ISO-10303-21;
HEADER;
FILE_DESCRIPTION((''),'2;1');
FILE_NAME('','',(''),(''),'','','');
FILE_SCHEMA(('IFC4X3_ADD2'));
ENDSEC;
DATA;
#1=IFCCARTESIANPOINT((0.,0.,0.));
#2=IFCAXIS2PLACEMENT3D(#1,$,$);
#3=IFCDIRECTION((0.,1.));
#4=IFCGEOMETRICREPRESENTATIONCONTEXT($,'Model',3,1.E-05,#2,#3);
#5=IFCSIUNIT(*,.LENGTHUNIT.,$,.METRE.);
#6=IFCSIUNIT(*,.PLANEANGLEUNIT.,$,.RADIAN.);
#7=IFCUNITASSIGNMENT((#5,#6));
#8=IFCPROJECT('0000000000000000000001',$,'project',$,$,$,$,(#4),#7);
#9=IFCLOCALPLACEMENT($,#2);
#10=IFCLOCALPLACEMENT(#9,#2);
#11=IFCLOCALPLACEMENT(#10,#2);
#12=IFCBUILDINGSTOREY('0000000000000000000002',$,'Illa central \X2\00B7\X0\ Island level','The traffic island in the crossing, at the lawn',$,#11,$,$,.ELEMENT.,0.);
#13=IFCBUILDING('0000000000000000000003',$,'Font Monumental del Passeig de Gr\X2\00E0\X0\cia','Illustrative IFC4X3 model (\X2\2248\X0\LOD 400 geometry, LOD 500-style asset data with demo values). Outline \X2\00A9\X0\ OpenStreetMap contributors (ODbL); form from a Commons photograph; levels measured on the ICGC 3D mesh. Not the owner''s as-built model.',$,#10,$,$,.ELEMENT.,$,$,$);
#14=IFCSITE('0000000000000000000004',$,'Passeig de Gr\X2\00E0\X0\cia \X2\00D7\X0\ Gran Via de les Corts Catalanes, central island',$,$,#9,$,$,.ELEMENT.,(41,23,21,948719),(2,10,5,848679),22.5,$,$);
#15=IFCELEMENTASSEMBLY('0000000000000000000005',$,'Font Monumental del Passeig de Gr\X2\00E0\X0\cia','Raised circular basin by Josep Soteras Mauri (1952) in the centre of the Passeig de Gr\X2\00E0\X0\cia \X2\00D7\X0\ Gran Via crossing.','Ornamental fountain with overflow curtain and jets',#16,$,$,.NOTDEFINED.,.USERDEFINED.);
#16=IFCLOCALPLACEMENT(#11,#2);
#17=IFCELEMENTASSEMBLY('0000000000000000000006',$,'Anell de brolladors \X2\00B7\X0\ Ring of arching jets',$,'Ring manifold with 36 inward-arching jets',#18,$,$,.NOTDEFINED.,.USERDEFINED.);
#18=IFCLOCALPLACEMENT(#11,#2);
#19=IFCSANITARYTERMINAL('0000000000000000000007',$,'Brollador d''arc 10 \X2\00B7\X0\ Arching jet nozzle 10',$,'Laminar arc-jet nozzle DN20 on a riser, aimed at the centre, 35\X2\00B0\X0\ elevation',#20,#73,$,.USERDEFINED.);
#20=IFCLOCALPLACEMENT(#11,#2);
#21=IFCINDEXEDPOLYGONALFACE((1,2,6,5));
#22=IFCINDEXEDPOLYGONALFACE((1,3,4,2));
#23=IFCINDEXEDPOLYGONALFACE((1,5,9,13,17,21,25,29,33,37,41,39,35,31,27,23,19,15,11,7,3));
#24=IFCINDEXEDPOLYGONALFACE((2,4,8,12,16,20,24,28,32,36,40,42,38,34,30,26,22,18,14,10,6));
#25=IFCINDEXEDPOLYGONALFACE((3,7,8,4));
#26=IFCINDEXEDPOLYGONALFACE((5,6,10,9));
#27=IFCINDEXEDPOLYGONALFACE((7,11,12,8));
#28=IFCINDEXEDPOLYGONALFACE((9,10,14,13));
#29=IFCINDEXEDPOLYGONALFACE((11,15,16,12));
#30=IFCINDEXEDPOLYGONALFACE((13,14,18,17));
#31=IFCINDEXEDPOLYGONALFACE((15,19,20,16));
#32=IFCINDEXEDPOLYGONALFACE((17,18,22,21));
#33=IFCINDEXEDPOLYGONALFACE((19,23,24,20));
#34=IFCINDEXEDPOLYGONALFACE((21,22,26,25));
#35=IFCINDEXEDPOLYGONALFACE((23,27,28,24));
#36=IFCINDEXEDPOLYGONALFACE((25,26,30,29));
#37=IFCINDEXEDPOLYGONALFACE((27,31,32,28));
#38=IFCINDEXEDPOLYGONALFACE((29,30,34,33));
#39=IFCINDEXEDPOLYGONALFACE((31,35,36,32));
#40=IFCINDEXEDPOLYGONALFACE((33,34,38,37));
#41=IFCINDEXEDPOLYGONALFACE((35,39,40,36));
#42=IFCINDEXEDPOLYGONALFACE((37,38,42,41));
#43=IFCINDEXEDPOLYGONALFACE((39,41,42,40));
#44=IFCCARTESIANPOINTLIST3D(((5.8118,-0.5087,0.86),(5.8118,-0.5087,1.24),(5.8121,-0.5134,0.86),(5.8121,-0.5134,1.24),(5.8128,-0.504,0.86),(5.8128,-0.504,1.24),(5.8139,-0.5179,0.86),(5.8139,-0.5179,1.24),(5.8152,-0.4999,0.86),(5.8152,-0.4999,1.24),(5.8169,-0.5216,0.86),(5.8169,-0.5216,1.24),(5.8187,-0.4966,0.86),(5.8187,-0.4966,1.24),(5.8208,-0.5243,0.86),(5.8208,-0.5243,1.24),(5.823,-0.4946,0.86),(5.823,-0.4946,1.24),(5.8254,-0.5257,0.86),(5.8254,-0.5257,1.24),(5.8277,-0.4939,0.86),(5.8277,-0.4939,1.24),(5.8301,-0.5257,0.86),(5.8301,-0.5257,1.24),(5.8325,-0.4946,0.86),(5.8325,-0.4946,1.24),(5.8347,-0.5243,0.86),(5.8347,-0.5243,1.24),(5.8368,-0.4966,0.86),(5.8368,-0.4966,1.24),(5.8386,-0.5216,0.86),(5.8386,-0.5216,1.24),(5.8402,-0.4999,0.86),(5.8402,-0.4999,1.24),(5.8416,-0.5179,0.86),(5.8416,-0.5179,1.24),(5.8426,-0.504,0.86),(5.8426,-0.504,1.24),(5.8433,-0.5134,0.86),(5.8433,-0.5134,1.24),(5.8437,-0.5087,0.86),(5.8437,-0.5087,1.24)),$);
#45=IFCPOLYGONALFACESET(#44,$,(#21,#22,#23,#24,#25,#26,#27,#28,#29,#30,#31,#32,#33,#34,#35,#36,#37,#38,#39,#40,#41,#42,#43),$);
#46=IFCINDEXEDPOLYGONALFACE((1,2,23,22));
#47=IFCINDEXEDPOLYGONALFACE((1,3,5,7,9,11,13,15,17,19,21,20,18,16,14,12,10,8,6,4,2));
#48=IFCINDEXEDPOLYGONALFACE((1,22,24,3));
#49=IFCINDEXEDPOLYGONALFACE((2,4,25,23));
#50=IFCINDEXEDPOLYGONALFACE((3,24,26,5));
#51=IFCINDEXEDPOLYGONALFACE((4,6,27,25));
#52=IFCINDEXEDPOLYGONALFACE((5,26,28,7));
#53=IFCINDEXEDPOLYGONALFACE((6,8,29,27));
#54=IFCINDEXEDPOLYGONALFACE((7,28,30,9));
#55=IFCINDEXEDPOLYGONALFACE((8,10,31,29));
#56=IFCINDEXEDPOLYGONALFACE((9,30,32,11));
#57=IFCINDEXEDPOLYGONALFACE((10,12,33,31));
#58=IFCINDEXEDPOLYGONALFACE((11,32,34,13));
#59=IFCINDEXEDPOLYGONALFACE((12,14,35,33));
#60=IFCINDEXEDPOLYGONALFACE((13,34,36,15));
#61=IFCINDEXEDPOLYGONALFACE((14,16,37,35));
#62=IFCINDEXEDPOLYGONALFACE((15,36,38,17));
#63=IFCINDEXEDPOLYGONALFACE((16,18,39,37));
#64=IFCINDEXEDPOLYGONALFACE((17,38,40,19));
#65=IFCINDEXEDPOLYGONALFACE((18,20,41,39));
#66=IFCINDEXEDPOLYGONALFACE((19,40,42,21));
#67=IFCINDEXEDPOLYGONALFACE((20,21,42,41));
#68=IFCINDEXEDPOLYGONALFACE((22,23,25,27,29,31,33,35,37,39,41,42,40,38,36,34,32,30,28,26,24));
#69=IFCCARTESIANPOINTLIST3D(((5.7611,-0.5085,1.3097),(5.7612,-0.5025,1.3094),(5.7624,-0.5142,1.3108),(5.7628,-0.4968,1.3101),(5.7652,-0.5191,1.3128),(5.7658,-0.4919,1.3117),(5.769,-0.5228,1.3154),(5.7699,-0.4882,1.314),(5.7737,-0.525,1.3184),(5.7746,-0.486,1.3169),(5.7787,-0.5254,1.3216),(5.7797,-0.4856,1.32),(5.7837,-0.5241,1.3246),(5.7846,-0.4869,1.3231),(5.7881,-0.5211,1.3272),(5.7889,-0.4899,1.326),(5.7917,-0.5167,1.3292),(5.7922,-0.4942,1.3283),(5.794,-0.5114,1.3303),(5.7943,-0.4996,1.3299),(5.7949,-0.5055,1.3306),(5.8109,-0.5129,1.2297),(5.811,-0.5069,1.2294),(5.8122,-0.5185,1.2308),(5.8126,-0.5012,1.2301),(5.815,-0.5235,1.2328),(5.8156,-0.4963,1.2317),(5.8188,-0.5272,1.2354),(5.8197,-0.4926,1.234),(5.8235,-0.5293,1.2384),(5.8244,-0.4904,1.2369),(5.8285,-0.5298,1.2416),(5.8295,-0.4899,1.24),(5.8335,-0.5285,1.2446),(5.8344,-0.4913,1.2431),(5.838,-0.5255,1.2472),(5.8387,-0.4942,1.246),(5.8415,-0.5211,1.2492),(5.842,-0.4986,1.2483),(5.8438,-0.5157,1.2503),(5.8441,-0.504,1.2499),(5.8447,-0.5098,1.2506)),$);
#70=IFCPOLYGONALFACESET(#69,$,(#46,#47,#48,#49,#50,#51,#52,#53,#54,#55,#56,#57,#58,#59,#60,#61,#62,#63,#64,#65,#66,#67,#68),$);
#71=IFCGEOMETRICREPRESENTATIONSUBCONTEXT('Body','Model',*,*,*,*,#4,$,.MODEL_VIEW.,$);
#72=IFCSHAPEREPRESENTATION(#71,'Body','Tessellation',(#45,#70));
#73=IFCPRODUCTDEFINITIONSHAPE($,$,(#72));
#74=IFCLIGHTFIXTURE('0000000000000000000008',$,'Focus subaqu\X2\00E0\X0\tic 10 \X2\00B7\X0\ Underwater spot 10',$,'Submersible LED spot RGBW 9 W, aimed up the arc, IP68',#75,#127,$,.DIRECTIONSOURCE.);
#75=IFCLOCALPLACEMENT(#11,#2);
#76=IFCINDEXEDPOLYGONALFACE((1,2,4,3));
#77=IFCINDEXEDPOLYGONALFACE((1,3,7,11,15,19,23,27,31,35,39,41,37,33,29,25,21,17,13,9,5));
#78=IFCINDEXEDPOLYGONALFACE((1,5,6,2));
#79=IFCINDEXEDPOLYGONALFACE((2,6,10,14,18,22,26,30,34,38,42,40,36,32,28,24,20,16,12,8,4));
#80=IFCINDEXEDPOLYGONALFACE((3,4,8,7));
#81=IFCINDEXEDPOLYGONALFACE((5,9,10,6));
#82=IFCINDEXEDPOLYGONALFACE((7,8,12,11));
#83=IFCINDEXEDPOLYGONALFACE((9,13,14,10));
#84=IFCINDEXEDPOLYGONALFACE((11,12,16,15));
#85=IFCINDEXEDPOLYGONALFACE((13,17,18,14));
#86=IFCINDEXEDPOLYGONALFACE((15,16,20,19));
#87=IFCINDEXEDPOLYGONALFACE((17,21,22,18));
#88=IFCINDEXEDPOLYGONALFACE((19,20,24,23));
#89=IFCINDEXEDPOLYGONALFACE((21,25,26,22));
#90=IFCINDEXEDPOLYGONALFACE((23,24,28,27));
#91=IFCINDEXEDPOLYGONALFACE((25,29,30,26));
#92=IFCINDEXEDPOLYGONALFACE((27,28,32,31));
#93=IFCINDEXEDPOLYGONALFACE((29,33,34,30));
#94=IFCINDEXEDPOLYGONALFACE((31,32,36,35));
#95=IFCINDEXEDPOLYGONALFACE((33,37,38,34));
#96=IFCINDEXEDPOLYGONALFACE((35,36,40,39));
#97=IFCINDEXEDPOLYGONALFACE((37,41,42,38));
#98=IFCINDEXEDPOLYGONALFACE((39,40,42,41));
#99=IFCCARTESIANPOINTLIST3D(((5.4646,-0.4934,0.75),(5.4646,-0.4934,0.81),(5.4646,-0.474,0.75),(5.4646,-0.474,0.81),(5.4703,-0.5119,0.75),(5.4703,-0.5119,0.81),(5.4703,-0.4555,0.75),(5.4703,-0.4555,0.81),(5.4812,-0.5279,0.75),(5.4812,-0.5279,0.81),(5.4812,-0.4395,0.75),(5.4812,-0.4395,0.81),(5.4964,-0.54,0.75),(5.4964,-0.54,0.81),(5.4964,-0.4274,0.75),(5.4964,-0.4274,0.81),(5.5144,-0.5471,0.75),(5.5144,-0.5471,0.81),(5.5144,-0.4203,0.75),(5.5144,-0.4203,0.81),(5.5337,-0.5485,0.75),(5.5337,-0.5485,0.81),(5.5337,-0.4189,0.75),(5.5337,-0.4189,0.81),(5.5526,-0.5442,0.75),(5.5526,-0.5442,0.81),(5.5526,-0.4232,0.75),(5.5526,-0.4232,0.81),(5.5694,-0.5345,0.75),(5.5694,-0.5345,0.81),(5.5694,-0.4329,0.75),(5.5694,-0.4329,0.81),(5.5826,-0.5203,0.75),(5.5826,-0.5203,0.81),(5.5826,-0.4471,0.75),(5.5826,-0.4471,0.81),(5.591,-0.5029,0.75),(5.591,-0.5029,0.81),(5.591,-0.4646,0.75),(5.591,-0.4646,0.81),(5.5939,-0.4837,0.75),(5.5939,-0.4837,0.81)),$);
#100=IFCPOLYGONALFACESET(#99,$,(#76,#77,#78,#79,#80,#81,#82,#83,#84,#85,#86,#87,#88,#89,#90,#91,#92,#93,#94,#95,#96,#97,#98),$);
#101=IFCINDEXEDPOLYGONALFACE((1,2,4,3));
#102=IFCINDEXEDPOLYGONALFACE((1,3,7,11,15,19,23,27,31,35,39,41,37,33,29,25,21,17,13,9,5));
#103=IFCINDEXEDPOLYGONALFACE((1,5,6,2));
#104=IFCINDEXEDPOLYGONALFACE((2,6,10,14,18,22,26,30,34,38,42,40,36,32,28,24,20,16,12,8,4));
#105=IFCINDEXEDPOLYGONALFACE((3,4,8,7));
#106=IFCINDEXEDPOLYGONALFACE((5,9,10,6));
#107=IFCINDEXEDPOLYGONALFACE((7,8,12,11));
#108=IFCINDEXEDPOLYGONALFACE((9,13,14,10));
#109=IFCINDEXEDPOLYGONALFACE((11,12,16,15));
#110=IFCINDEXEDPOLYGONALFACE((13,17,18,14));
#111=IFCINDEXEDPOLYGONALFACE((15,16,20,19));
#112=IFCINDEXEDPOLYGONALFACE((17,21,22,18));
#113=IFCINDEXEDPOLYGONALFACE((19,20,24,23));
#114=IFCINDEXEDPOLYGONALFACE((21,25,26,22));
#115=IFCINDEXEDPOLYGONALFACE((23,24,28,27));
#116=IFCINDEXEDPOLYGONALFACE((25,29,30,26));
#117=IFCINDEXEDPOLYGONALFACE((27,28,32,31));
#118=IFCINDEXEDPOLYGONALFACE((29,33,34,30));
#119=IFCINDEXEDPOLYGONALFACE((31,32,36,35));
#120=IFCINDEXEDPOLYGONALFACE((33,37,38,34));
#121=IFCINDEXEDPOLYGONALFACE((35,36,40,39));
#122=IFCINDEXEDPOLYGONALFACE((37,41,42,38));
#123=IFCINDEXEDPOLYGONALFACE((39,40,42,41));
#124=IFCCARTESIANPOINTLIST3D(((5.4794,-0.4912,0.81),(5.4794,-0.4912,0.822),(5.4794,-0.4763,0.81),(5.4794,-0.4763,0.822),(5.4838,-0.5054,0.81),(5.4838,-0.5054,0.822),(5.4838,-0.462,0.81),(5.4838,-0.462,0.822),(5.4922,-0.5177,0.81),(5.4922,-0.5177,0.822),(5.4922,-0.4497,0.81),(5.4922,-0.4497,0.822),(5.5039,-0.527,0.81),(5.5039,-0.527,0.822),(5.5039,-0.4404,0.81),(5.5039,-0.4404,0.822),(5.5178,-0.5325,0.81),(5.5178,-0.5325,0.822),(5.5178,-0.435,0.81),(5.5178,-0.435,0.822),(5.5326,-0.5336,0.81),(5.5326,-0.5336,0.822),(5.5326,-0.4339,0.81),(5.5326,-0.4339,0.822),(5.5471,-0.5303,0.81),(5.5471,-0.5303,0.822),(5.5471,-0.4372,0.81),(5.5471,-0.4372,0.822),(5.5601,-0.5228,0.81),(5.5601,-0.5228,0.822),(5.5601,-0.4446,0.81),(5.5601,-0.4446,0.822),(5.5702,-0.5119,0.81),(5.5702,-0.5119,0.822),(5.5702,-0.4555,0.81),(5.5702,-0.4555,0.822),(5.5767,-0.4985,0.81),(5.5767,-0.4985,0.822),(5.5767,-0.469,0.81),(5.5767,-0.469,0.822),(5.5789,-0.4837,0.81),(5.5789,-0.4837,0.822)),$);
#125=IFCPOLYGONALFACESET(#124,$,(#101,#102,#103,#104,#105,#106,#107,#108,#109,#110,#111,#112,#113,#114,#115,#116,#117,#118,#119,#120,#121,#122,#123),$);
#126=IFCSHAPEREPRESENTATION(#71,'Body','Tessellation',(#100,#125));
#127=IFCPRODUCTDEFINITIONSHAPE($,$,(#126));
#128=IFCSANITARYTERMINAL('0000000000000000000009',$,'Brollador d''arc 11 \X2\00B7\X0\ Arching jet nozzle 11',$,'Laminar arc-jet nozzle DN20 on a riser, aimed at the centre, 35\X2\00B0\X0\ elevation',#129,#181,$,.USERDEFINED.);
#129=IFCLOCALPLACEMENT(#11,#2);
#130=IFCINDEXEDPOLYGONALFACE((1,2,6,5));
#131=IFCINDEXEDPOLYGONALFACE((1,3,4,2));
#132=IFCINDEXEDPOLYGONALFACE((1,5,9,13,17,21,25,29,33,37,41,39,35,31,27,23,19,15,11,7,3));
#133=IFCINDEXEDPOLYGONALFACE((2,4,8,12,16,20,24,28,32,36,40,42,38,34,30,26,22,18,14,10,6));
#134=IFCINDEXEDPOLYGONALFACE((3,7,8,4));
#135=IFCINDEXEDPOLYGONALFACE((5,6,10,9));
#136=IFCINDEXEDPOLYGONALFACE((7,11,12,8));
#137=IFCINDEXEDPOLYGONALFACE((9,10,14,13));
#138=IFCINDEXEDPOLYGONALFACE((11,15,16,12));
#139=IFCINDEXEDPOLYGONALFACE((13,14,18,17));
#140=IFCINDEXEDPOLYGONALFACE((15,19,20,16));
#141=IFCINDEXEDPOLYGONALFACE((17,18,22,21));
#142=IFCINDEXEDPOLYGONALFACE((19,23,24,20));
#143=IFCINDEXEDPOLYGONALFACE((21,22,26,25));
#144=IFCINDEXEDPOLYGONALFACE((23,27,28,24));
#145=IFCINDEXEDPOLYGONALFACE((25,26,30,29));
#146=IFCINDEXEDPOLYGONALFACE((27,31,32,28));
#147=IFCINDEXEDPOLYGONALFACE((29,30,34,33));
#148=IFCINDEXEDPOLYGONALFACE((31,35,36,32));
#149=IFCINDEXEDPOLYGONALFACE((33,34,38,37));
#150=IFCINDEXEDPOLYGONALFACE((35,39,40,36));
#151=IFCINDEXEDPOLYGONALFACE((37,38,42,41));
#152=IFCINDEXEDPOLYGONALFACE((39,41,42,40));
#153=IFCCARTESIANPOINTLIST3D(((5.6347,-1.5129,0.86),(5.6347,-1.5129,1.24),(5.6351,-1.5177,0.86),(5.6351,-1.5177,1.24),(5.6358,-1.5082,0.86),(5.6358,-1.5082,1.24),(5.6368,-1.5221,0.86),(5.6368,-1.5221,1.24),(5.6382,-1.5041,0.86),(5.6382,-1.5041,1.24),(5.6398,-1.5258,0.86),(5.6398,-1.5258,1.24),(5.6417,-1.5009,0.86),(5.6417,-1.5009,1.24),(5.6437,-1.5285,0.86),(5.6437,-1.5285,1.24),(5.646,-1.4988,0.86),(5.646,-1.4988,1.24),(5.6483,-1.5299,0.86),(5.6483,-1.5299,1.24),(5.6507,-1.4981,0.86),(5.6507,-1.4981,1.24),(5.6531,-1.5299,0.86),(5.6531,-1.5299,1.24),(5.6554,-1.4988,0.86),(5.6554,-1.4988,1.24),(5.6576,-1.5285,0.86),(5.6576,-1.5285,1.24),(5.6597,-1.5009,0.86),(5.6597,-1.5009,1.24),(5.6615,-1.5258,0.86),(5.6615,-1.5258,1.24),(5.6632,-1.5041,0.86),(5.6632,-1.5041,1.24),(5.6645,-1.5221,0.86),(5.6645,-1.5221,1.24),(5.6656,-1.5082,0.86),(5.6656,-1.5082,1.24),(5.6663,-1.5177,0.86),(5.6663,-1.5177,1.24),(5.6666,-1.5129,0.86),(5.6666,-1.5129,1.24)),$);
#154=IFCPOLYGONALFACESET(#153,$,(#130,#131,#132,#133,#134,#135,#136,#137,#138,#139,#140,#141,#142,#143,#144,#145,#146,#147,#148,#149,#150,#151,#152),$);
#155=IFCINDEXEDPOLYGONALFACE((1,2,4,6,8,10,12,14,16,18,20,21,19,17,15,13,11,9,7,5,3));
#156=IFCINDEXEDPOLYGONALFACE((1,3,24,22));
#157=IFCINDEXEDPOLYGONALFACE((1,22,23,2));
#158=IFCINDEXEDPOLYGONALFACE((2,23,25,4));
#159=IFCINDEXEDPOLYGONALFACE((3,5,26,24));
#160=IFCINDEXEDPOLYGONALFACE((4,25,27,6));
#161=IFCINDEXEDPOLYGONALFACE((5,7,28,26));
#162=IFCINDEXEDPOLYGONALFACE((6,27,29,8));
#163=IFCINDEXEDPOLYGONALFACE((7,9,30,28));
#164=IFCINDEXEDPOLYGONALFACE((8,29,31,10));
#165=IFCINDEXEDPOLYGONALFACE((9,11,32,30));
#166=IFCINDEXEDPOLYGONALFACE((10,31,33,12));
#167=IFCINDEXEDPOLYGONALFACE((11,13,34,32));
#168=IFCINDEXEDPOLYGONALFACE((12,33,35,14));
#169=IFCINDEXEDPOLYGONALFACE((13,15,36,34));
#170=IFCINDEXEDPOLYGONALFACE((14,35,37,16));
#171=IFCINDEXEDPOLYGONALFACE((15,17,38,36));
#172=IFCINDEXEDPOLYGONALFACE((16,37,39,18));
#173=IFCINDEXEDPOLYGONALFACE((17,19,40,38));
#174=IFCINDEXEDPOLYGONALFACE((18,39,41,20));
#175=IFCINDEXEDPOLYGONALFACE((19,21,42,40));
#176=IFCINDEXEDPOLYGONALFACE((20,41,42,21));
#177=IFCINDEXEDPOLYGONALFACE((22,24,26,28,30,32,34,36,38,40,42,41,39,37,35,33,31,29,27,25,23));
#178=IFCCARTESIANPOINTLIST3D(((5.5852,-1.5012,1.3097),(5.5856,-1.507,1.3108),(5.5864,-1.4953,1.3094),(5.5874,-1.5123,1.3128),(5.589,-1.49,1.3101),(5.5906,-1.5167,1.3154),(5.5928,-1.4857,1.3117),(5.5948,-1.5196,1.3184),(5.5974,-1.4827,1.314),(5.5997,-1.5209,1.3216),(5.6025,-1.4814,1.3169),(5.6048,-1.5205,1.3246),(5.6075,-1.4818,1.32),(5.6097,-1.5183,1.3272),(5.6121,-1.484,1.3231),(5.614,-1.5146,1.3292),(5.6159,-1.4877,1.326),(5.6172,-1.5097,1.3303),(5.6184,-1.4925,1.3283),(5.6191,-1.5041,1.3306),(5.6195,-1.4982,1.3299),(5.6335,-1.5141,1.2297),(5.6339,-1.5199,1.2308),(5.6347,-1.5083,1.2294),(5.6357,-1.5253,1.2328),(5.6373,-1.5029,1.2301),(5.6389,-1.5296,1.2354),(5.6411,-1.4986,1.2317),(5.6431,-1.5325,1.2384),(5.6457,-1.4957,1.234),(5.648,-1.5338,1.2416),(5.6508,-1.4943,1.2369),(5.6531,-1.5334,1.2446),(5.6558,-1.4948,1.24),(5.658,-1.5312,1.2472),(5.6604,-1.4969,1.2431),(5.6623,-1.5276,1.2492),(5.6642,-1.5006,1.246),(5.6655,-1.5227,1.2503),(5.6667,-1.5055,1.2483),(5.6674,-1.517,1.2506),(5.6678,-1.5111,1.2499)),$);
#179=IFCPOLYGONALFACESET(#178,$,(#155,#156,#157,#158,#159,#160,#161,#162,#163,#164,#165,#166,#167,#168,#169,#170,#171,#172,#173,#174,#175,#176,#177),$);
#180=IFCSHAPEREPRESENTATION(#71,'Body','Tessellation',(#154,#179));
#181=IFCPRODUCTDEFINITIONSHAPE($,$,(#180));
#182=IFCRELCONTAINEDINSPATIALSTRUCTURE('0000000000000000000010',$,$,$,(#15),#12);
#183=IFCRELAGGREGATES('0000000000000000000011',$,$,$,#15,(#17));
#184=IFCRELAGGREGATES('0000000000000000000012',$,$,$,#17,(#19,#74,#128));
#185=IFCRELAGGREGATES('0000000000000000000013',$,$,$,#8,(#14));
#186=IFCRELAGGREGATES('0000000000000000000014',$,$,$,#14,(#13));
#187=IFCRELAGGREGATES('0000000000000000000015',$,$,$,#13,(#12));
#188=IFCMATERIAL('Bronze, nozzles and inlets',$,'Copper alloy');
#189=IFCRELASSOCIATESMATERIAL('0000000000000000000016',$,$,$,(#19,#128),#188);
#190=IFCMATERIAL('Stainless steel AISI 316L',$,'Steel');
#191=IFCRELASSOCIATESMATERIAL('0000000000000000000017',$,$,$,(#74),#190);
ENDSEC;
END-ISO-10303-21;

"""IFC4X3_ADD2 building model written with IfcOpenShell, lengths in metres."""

from ifc_helpers import new_model, si_unit, direction, frame, origin, origin_2d_with_axis, place, context, subcontext, project, spatial, circle, extrude, material, element, aggregate, save


model = new_model("IFC4X3_ADD2")

# Units and contexts
model_context = context("Model", 3, precision=1e-05, world=origin(), true_north=direction((0.0, 1.0)))
body_context = subcontext(model_context, "Body", "Model", "MODEL_VIEW")
ifc_project = project(units=[si_unit("LENGTHUNIT", "METRE"), si_unit("PLANEANGLEUNIT", "RADIAN")], contexts=[model_context])

# Site, building, storey
site_placement = place(None, origin())
site = spatial("IfcSite", under=ifc_project, at=site_placement, Name="Passeig de Gràcia × Gran Via de les Corts Catalanes, central island", CompositionType="ELEMENT", RefLatitude=(41, 23, 21, 948719), RefLongitude=(2, 10, 5, 848679), RefElevation=22.5)
building_placement = place(site_placement, origin())
building = spatial("IfcBuilding", under=site, at=building_placement, Name="Font Monumental del Passeig de Gràcia", Description="Illustrative IFC4X3 model (≈LOD 400 geometry, LOD 500-style asset data with demo values). Outline © OpenStreetMap contributors (ODbL); form from a Commons photograph; levels measured on the ICGC 3D mesh. Not the owner's as-built model.", CompositionType="ELEMENT")
storey_placement = place(building_placement, origin())
storey = spatial("IfcBuildingStorey", under=building, at=storey_placement, Name="Illa central · Island level", Description="The traffic island in the crossing, at the lawn", CompositionType="ELEMENT", Elevation=0.0)

# Element assemblies, sanitary terminals, light fixture
assembly_1_placement = place(building_placement, origin())
assembly_1 = element("IfcElementAssembly", 1, at=assembly_1_placement, inside=storey, Name="Font Monumental del Passeig de Gràcia", Description="Raised circular basin by Josep Soteras Mauri (1952) in the centre of the Passeig de Gràcia × Gran Via crossing.", ObjectType="Ornamental fountain with overflow curtain and jets", AssemblyPlace="NOTDEFINED", PredefinedType="USERDEFINED")
assembly_2_placement = place(building_placement, origin())
assembly_2 = element("IfcElementAssembly", 2, at=assembly_2_placement, Name="Anell de brolladors · Ring of arching jets", ObjectType="Ring manifold with 36 inward-arching jets", AssemblyPlace="NOTDEFINED", PredefinedType="USERDEFINED")
aggregate(assembly_1, [assembly_2])
ifc_material_1 = material(Name="Bronze, nozzles and inlets", Category="Copper alloy")
ifc_material_2 = material(Name="Stainless steel AISI 316L", Category="Steel")
sanitary_terminal_1_placement = place(building_placement, origin())
sanitary_terminal_1 = element("IfcSanitaryTerminal", 3, at=sanitary_terminal_1_placement, material=ifc_material_1, Name="Brollador d'arc 10 · Arching jet nozzle 10", ObjectType="Laminar arc-jet nozzle DN20 on a riser, aimed at the centre, 35° elevation", PredefinedType="USERDEFINED", context=body_context, shape_type="SweptSolid", body=[
    extrude(circle(Radius=0.016, at=origin_2d_with_axis()), frame((5.8277, -0.5099, 0.86), z_axis=(0.0, 0.0, 1.0), x_axis=(0.0, 1.0, 0.0)), (0.0, 0.0, 1.0), 0.38),
    extrude(circle(Radius=0.02, at=origin_2d_with_axis()), frame((5.8277, -0.5099, 1.24), z_axis=(-0.527982, 0.046192, 0.847998), x_axis=(0.087156, 0.996195, 0.0)), (0.0, 0.0, 1.0), 0.0943),
])
light_fixture_1_placement = place(building_placement, origin())
light_fixture_1 = element("IfcLightFixture", 4, at=light_fixture_1_placement, material=ifc_material_2, Name="Focus subaquàtic 10 · Underwater spot 10", ObjectType="Submersible LED spot RGBW 9 W, aimed up the arc, IP68", PredefinedType="DIRECTIONSOURCE", context=body_context, shape_type="SweptSolid", body=[
    extrude(circle(Radius=0.065, at=origin_2d_with_axis()), frame((5.5289, -0.4837, 0.75)), (0.0, 0.0, 1.0), 0.06),
    extrude(circle(Radius=0.05, at=origin_2d_with_axis()), frame((5.5289, -0.4837, 0.81)), (0.0, 0.0, 1.0), 0.012),
])
sanitary_terminal_2_placement = place(building_placement, origin())
sanitary_terminal_2 = element("IfcSanitaryTerminal", 5, at=sanitary_terminal_2_placement, material=ifc_material_1, Name="Brollador d'arc 11 · Arching jet nozzle 11", ObjectType="Laminar arc-jet nozzle DN20 on a riser, aimed at the centre, 35° elevation", PredefinedType="USERDEFINED", context=body_context, shape_type="SweptSolid", body=[
    extrude(circle(Radius=0.016, at=origin_2d_with_axis()), frame((5.6507, -1.5141, 0.86), z_axis=(0.0, 0.0, 1.0), x_axis=(0.0, 1.0, 0.0)), (0.0, 0.0, 1.0), 0.38),
    extrude(circle(Radius=0.02, at=origin_2d_with_axis()), frame((5.6507, -1.5141, 1.24), z_axis=(-0.51194, 0.137174, 0.847998), x_axis=(0.258819, 0.965926, 0.0)), (0.0, 0.0, 1.0), 0.0943),
])
aggregate(assembly_2, [sanitary_terminal_1, light_fixture_1, sanitary_terminal_2])

save(model, "model.ifc")
